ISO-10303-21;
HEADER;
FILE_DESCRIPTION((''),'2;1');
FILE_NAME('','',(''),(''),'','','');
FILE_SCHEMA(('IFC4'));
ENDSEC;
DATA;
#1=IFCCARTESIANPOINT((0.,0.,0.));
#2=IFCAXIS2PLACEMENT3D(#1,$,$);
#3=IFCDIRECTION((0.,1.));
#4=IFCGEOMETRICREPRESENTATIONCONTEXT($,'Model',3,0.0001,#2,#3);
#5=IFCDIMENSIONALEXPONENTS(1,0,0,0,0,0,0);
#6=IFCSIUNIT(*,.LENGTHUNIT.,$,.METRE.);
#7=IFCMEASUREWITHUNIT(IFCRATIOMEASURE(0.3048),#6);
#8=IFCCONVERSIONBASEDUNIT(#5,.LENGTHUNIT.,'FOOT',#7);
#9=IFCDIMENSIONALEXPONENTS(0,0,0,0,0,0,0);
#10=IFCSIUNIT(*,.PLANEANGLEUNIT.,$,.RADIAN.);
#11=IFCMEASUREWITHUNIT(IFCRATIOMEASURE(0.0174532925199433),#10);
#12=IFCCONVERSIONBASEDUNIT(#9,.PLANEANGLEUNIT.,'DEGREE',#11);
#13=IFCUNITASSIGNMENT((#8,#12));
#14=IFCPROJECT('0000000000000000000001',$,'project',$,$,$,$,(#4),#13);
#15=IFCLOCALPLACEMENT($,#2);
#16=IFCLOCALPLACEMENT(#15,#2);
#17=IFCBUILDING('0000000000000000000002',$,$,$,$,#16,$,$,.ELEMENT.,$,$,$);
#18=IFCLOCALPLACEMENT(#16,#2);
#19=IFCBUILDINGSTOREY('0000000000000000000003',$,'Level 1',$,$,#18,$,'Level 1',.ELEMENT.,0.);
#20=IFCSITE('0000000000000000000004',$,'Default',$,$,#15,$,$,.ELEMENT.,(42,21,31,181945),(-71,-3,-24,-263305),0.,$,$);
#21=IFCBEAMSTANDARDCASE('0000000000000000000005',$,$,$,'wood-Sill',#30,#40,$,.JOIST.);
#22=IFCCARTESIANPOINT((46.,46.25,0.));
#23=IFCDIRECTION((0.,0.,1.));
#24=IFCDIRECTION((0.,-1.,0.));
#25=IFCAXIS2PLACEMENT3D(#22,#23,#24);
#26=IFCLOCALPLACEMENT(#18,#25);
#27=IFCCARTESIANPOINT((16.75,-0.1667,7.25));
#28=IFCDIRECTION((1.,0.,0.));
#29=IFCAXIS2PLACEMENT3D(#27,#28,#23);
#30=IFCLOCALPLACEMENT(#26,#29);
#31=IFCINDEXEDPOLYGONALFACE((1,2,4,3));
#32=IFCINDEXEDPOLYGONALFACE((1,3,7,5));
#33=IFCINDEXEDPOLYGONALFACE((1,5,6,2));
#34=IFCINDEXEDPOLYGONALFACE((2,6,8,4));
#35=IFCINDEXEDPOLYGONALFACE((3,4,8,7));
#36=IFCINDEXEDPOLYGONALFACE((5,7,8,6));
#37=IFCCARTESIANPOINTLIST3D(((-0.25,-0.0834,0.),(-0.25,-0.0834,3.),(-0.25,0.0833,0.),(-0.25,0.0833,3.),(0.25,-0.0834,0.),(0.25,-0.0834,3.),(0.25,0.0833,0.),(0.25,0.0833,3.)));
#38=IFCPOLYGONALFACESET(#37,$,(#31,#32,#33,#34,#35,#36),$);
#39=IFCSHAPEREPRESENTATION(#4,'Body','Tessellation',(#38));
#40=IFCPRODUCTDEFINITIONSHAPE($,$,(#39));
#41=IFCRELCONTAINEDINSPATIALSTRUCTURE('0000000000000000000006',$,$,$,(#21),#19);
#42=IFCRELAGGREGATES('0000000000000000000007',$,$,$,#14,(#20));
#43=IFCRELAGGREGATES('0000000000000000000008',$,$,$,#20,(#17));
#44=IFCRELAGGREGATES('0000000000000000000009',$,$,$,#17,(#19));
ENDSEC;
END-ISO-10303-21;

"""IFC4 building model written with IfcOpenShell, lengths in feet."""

from ifc_helpers import new_model, entity, si_unit, converted_unit, direction, frame, origin, origin_with_axes, place, context, project, spatial, rectangle, extrude, element, save


model = new_model("IFC4")

# Units and contexts
model_context = context("Model", 3, precision=0.0001, world=origin(), true_north=direction((0.0, 1.0)))
ifc_project = project(units=[converted_unit("LENGTHUNIT", "FOOT", entity("IfcRatioMeasure", 0.3048), si_unit("LENGTHUNIT", "METRE"), dimensions=[1, 0, 0, 0, 0, 0, 0]), converted_unit("PLANEANGLEUNIT", "DEGREE", entity("IfcRatioMeasure", 0.0174532925199433), si_unit("PLANEANGLEUNIT", "RADIAN"), dimensions=[0, 0, 0, 0, 0, 0, 0])], contexts=[model_context])

# Site, building, storey
site_placement = place(None, origin())
site = spatial("IfcSite", under=ifc_project, at=site_placement, Name="Default", CompositionType="ELEMENT", RefLatitude=(42, 21, 31, 181945), RefLongitude=(-71, -3, -24, -263305), RefElevation=0.0)
building_placement = place(site_placement, origin())
building = spatial("IfcBuilding", under=site, at=building_placement, CompositionType="ELEMENT")
storey_placement = place(building_placement, origin())
storey = spatial("IfcBuildingStorey", under=building, at=storey_placement, Name="Level 1", LongName="Level 1", CompositionType="ELEMENT", Elevation=0.0)

# Shared definitions
placement_1 = place(storey_placement, frame((46.0, 46.25, 0.0), z_axis=(0.0, 0.0, 1.0), x_axis=(0.0, -1.0, 0.0)))

# Beam
for number, where, z_axis, x_axis in (
    (1, (16.75, -0.1667, 7.25), (1.0, 0.0, 0.0), (0.0, 0.0, 1.0)),
):
    element("IfcBeamStandardCase", number, at=place(placement_1, frame(where, z_axis=z_axis, x_axis=x_axis)), inside=storey, ObjectType="wood-Sill", PredefinedType="JOIST", context=model_context, shape_type="SweptSolid", body=[
        extrude(rectangle(XDim=0.5, YDim=0.1667), origin_with_axes(), (0.0, 0.0, 1.0), 3.0),
    ])

save(model, "model.ifc")
